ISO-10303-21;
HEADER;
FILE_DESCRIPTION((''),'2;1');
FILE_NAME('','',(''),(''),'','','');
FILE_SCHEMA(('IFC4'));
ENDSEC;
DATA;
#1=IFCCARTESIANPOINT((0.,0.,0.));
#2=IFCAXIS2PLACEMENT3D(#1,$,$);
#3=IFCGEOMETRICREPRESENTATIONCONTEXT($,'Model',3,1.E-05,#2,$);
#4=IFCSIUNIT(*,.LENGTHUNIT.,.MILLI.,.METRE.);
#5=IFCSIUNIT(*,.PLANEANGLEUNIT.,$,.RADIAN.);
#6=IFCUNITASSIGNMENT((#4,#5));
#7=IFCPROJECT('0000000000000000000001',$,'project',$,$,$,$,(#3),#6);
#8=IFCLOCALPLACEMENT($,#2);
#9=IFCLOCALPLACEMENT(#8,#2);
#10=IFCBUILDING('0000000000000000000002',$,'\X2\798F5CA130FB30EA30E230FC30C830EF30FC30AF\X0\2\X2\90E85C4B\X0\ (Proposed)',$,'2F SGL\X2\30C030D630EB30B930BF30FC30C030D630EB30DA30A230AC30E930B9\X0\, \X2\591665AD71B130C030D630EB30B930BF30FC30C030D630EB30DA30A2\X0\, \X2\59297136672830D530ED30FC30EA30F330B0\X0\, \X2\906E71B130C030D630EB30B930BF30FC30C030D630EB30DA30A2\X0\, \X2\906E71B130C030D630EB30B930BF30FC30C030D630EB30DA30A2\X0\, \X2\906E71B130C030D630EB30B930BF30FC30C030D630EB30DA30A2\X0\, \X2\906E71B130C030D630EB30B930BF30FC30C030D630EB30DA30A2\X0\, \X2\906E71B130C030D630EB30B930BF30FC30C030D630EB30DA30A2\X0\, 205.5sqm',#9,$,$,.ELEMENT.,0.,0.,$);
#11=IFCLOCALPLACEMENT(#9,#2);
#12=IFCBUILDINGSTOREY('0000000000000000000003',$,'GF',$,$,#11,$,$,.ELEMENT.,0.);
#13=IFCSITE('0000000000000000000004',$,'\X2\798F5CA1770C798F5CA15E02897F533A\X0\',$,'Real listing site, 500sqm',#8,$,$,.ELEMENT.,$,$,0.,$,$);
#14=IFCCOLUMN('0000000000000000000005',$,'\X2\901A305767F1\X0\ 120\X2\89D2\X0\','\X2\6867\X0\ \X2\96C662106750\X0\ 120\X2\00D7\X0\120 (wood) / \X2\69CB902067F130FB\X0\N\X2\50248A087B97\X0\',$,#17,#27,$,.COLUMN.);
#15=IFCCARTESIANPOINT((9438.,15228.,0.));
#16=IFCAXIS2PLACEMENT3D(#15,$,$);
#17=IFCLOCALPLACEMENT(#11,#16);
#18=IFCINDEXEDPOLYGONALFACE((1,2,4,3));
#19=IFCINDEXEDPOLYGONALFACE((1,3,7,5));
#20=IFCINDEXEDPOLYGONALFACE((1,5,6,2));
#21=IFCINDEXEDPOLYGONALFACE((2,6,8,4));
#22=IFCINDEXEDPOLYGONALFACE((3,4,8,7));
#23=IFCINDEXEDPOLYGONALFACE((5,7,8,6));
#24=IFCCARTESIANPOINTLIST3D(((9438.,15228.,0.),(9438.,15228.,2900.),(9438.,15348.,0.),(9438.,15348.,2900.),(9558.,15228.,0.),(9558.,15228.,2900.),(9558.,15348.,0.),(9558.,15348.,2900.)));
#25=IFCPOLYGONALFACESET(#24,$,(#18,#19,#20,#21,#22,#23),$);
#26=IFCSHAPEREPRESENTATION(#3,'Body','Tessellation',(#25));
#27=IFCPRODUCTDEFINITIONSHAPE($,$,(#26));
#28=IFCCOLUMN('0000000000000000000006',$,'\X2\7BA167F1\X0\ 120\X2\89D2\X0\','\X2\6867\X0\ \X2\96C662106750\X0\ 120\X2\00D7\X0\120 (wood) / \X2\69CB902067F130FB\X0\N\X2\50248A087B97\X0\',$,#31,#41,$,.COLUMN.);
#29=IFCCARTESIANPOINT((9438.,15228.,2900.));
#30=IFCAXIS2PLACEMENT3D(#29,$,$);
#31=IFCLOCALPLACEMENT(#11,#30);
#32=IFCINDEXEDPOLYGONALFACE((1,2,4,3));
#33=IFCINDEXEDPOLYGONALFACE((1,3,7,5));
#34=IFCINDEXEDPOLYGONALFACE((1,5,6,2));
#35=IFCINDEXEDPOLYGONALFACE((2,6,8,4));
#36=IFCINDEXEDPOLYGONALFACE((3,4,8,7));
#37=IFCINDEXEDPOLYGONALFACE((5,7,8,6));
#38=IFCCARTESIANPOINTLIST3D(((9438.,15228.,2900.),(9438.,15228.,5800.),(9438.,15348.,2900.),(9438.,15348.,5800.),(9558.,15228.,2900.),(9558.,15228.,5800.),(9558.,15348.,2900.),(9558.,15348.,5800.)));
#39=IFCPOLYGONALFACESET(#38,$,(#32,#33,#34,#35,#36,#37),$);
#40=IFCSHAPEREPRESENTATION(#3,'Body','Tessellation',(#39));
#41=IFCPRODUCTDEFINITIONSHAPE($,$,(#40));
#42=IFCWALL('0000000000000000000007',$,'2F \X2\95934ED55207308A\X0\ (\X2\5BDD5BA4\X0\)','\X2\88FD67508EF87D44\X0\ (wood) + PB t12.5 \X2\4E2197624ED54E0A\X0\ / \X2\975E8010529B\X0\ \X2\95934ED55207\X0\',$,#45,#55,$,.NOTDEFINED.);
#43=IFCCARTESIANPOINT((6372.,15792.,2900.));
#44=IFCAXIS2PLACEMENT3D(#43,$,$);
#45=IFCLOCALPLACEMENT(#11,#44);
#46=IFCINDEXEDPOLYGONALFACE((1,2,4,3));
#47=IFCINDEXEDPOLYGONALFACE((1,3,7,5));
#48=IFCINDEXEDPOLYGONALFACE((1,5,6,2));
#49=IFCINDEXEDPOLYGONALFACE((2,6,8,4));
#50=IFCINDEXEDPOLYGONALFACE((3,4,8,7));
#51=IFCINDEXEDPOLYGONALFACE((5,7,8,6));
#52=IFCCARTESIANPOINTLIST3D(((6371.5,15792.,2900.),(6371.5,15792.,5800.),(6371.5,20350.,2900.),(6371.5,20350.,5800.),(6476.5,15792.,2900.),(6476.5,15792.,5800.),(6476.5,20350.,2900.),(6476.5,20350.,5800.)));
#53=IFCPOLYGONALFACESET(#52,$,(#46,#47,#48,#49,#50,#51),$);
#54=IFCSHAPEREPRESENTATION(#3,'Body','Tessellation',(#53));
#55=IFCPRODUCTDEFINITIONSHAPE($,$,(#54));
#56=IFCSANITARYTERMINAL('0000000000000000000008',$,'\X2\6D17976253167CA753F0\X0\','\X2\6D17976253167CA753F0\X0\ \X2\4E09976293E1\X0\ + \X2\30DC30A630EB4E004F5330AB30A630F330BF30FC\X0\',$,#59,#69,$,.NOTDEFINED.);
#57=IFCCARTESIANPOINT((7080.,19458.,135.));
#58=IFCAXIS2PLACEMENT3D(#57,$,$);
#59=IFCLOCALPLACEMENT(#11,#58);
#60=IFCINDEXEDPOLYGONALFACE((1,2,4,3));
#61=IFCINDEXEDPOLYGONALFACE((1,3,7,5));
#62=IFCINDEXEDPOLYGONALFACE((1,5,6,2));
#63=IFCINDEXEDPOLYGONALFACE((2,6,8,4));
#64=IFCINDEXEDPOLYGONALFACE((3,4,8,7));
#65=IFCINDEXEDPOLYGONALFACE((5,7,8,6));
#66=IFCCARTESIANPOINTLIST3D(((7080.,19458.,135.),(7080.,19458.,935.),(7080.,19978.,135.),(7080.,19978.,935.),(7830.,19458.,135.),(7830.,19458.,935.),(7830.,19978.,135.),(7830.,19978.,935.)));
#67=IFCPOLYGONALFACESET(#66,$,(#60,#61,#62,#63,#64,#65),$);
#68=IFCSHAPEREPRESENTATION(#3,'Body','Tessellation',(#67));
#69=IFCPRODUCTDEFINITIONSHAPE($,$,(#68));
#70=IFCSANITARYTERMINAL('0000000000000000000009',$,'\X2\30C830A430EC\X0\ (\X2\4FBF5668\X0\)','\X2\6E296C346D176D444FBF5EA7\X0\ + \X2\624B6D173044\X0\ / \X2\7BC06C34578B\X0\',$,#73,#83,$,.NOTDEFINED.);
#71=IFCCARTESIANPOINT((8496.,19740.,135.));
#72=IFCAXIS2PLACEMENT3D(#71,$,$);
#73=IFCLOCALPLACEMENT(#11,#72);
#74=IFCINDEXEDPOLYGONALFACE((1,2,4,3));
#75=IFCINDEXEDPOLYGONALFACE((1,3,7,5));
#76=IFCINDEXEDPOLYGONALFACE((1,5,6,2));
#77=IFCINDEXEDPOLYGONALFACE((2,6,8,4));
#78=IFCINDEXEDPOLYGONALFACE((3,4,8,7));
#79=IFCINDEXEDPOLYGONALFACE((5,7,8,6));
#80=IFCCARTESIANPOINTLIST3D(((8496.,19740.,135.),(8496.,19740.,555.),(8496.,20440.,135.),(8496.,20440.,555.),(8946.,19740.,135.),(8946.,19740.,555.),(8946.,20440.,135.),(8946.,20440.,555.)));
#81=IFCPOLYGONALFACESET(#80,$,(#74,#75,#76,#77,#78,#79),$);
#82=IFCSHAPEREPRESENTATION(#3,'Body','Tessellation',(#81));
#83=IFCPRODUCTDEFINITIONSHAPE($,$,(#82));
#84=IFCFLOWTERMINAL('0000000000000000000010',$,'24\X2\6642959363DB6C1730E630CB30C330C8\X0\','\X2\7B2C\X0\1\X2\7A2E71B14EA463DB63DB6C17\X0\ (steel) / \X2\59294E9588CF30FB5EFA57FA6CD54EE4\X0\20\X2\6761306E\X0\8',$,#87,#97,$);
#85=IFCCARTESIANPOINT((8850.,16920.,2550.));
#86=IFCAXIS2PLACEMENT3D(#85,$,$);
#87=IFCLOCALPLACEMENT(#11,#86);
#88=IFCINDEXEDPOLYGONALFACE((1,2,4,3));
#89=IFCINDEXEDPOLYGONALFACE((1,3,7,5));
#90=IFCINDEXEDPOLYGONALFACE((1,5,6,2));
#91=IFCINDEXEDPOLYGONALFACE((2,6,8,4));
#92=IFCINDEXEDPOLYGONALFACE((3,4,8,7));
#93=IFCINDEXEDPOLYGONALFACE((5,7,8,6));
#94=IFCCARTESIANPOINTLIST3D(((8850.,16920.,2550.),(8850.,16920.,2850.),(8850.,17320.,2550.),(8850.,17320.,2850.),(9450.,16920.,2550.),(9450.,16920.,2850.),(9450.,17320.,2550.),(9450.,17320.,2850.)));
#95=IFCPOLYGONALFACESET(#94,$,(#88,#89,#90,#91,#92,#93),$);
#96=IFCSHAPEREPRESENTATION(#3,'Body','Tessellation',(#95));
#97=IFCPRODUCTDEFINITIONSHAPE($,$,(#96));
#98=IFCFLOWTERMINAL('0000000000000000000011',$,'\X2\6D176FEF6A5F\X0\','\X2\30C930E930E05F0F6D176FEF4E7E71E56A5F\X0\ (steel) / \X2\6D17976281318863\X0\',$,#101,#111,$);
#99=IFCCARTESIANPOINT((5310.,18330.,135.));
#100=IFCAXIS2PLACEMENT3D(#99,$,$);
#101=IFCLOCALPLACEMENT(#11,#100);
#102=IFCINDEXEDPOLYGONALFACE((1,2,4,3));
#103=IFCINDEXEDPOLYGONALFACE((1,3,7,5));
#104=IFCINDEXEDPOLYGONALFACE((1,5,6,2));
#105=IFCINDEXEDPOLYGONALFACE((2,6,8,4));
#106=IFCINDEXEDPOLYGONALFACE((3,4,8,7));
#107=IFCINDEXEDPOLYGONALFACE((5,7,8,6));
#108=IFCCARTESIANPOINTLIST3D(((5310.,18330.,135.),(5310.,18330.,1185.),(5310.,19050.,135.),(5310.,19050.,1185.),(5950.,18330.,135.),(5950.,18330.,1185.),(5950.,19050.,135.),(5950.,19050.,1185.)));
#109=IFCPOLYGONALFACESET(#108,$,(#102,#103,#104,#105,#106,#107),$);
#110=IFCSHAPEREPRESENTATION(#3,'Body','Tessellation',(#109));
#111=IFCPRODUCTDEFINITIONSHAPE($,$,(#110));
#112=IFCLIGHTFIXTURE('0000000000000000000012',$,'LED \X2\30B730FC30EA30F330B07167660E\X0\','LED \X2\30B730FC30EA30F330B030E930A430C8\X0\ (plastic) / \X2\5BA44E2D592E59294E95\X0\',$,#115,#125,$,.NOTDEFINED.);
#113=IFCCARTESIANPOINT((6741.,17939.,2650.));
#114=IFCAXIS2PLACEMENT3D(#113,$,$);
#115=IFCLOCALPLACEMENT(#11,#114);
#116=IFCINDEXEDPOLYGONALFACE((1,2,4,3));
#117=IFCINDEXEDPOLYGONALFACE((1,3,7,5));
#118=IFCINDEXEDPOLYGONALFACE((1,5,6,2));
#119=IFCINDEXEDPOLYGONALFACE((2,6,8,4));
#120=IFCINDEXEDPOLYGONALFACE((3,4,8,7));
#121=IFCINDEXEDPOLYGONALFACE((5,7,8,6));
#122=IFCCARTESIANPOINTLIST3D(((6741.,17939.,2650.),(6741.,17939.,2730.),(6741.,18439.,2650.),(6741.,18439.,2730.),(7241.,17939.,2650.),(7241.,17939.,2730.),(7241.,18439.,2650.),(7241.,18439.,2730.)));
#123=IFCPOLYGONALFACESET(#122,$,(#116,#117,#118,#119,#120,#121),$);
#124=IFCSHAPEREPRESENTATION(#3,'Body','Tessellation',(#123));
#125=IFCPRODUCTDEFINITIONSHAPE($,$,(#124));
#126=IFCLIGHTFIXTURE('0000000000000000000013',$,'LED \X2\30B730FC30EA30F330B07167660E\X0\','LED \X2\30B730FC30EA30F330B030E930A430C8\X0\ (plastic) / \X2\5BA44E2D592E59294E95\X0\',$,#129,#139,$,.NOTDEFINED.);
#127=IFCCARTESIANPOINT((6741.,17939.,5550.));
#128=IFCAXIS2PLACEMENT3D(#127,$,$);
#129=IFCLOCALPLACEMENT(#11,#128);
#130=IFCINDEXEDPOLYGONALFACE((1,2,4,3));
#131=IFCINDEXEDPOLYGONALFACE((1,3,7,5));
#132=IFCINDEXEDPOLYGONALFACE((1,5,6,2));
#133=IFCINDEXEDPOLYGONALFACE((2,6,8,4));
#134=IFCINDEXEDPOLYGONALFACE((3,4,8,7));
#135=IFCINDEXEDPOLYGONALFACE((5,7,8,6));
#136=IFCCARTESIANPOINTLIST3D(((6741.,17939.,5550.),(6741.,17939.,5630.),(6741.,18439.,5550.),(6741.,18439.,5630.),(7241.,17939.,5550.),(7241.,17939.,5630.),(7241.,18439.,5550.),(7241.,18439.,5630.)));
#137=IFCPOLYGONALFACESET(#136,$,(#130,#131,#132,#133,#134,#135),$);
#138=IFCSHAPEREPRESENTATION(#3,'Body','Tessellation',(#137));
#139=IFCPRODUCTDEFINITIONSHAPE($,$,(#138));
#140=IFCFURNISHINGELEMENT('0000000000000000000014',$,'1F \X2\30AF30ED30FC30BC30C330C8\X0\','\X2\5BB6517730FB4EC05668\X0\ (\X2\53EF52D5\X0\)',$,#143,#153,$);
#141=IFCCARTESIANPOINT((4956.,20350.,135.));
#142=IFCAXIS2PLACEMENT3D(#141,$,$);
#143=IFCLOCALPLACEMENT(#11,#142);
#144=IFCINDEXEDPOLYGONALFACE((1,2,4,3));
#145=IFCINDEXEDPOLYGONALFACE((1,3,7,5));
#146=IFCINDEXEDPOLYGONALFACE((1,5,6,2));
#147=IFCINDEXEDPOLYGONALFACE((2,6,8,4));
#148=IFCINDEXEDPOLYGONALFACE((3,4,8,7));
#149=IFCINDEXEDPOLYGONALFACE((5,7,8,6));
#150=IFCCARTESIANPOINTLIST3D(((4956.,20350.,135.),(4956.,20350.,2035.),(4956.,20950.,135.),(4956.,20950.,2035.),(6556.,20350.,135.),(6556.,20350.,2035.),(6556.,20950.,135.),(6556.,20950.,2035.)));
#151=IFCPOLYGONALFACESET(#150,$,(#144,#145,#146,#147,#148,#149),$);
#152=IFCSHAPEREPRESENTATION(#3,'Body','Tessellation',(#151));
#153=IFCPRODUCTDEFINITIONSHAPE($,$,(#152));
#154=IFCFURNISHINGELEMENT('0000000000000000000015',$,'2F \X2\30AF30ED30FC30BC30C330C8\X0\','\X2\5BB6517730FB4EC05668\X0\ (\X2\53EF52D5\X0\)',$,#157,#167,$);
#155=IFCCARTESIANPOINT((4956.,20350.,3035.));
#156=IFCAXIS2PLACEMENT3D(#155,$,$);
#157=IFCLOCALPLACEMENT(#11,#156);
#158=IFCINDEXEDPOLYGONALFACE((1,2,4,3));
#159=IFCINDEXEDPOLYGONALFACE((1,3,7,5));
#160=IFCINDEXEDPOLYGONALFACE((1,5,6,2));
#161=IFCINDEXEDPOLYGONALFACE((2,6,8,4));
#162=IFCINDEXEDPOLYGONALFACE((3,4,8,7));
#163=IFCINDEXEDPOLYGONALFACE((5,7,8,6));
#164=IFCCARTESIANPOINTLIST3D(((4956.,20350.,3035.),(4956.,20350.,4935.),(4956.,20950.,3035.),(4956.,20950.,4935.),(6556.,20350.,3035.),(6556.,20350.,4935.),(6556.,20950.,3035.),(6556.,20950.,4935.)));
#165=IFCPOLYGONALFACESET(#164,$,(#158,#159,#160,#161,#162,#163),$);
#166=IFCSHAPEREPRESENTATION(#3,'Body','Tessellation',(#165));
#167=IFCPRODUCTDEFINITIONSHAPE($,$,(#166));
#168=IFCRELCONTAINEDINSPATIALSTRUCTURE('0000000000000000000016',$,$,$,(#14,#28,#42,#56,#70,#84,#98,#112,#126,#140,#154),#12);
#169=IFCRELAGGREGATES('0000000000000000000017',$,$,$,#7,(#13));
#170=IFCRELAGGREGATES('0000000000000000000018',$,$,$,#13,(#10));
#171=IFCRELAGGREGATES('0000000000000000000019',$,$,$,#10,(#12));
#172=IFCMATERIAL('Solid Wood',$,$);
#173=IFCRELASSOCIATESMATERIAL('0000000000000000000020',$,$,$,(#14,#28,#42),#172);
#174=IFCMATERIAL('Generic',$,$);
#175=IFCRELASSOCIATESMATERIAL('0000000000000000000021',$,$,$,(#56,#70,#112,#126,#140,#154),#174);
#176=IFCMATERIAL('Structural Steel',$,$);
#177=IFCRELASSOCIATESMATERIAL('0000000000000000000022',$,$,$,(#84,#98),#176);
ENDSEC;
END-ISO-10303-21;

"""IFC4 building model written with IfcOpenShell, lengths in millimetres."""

from ifc_helpers import new_model, si_unit, frame, frame_2d, origin, place, context, project, spatial, rectangle, extrude, material, element, save


model = new_model("IFC4")

# Units and contexts
model_context = context("Model", 3, precision=1e-05, world=origin())
ifc_project = project(units=[si_unit("LENGTHUNIT", "METRE", prefix="MILLI"), si_unit("PLANEANGLEUNIT", "RADIAN")], contexts=[model_context])

# Site, building, storey
site_placement = place(None, origin())
site = spatial("IfcSite", under=ifc_project, at=site_placement, Name="福岡県福岡市西区", ObjectType="Real listing site, 500sqm", CompositionType="ELEMENT", RefElevation=0.0)
building_placement = place(site_placement, origin())
building = spatial("IfcBuilding", under=site, at=building_placement, Name="福岡・リモートワーク2部屋 (Proposed)", ObjectType="2F SGLダブルスターダブルペアガラス, 外断熱ダブルスターダブルペア, 天然木フローリング, 遮熱ダブルスターダブルペア, 遮熱ダブルスターダブルペア, 遮熱ダブルスターダブルペア, 遮熱ダブルスターダブルペア, 遮熱ダブルスターダブルペア, 205.5sqm", CompositionType="ELEMENT", ElevationOfRefHeight=0.0, ElevationOfTerrain=0.0)
storey_placement = place(building_placement, origin())
storey = spatial("IfcBuildingStorey", under=building, at=storey_placement, Name="GF", CompositionType="ELEMENT", Elevation=0.0)

# Columns
ifc_material_1 = material(Name="Solid Wood")
column_1_placement = place(storey_placement, frame((9438.0, 15228.0, 0.0)))
element("IfcColumn", 1, at=column_1_placement, inside=storey, material=ifc_material_1, Name="通し柱 120角", Description="桧 集成材 120×120 (wood) / 構造柱・N値計算", PredefinedType="COLUMN", context=model_context, shape_type="SweptSolid", body=[
    extrude(rectangle(XDim=120.0, YDim=120.0, at=frame_2d((60.0, 60.0))), frame((9438.0, 15228.0, 0.0)), (0.0, 0.0, 1.0), 2900.0),
])
column_2_placement = place(storey_placement, frame((9438.0, 15228.0, 2900.0)))
element("IfcColumn", 2, at=column_2_placement, inside=storey, material=ifc_material_1, Name="管柱 120角", Description="桧 集成材 120×120 (wood) / 構造柱・N値計算", PredefinedType="COLUMN", context=model_context, shape_type="SweptSolid", body=[
    extrude(rectangle(XDim=120.0, YDim=120.0, at=frame_2d((60.0, 60.0))), frame((9438.0, 15228.0, 2900.0)), (0.0, 0.0, 1.0), 2900.0),
])

# Wall
wall_1_placement = place(storey_placement, frame((6372.0, 15792.0, 2900.0)))
element("IfcWall", 3, at=wall_1_placement, inside=storey, material=ifc_material_1, Name="2F 間仕切り (寝室)", Description="製材軸組 (wood) + PB t12.5 両面仕上 / 非耐力 間仕切", PredefinedType="NOTDEFINED", context=model_context, shape_type="SweptSolid", body=[
    extrude(rectangle(XDim=105.0, YDim=4558.0, at=frame_2d((52.0, 2279.0))), frame((6372.0, 15792.0, 2900.0)), (0.0, 0.0, 1.0), 2900.0),
])

# Sanitary terminals
ifc_material_2 = material(Name="Generic")
sanitary_terminal_1_placement = place(storey_placement, frame((7080.0, 19458.0, 135.0)))
element("IfcSanitaryTerminal", 4, at=sanitary_terminal_1_placement, inside=storey, material=ifc_material_2, Name="洗面化粧台", Description="洗面化粧台 三面鏡 + ボウル一体カウンター", PredefinedType="NOTDEFINED", context=model_context, shape_type="SweptSolid", body=[
    extrude(rectangle(XDim=750.0, YDim=520.0, at=frame_2d((375.0, 260.0))), frame((7080.0, 19458.0, 135.0)), (0.0, 0.0, 1.0), 800.0),
])
sanitary_terminal_2_placement = place(storey_placement, frame((8496.0, 19740.0, 135.0)))
element("IfcSanitaryTerminal", 5, at=sanitary_terminal_2_placement, inside=storey, material=ifc_material_2, Name="トイレ (便器)", Description="温水洗浄便座 + 手洗い / 節水型", PredefinedType="NOTDEFINED", context=model_context, shape_type="SweptSolid", body=[
    extrude(rectangle(XDim=450.0, YDim=700.0, at=frame_2d((225.0, 350.0))), frame((8496.0, 19740.0, 135.0)), (0.0, 0.0, 1.0), 420.0),
])

# Flow terminals
ifc_material_3 = material(Name="Structural Steel")
flow_terminal_1_placement = place(storey_placement, frame((8850.0, 16920.0, 2550.0)))
element("IfcFlowTerminal", 6, at=flow_terminal_1_placement, inside=storey, material=ifc_material_3, Name="24時間換気ユニット", Description="第1種熱交換換気 (steel) / 天井裏・建基法令20条の8", context=model_context, shape_type="SweptSolid", body=[
    extrude(rectangle(XDim=600.0, YDim=400.0, at=frame_2d((300.0, 200.0))), frame((8850.0, 16920.0, 2550.0)), (0.0, 0.0, 1.0), 300.0),
])
flow_terminal_2_placement = place(storey_placement, frame((5310.0, 18330.0, 135.0)))
element("IfcFlowTerminal", 7, at=flow_terminal_2_placement, inside=storey, material=ifc_material_3, Name="洗濯機", Description="ドラム式洗濯乾燥機 (steel) / 洗面脱衣", context=model_context, shape_type="SweptSolid", body=[
    extrude(rectangle(XDim=640.0, YDim=720.0, at=frame_2d((320.0, 360.0))), frame((5310.0, 18330.0, 135.0)), (0.0, 0.0, 1.0), 1050.0),
])

# Light fixtures
light_fixture_1_placement = place(storey_placement, frame((6741.0, 17939.0, 2650.0)))
element("IfcLightFixture", 8, at=light_fixture_1_placement, inside=storey, material=ifc_material_2, Name="LED シーリング照明", Description="LED シーリングライト (plastic) / 室中央天井", PredefinedType="NOTDEFINED", context=model_context, shape_type="SweptSolid", body=[
    extrude(rectangle(XDim=500.0, YDim=500.0, at=frame_2d((250.0, 250.0))), frame((6741.0, 17939.0, 2650.0)), (0.0, 0.0, 1.0), 80.0),
])
light_fixture_2_placement = place(storey_placement, frame((6741.0, 17939.0, 5550.0)))
element("IfcLightFixture", 9, at=light_fixture_2_placement, inside=storey, material=ifc_material_2, Name="LED シーリング照明", Description="LED シーリングライト (plastic) / 室中央天井", PredefinedType="NOTDEFINED", context=model_context, shape_type="SweptSolid", body=[
    extrude(rectangle(XDim=500.0, YDim=500.0, at=frame_2d((250.0, 250.0))), frame((6741.0, 17939.0, 5550.0)), (0.0, 0.0, 1.0), 80.0),
])

# Furnishing elements
furnishing_1_placement = place(storey_placement, frame((4956.0, 20350.0, 135.0)))
element("IfcFurnishingElement", 10, at=furnishing_1_placement, inside=storey, material=ifc_material_2, Name="1F クローゼット", Description="家具・什器 (可動)", context=model_context, shape_type="SweptSolid", body=[
    extrude(rectangle(XDim=1600.0, YDim=600.0, at=frame_2d((800.0, 300.0))), frame((4956.0, 20350.0, 135.0)), (0.0, 0.0, 1.0), 1900.0),
])
furnishing_2_placement = place(storey_placement, frame((4956.0, 20350.0, 3035.0)))
element("IfcFurnishingElement", 11, at=furnishing_2_placement, inside=storey, material=ifc_material_2, Name="2F クローゼット", Description="家具・什器 (可動)", context=model_context, shape_type="SweptSolid", body=[
    extrude(rectangle(XDim=1600.0, YDim=600.0, at=frame_2d((800.0, 300.0))), frame((4956.0, 20350.0, 3035.0)), (0.0, 0.0, 1.0), 1900.0),
])

save(model, "model.ifc")
